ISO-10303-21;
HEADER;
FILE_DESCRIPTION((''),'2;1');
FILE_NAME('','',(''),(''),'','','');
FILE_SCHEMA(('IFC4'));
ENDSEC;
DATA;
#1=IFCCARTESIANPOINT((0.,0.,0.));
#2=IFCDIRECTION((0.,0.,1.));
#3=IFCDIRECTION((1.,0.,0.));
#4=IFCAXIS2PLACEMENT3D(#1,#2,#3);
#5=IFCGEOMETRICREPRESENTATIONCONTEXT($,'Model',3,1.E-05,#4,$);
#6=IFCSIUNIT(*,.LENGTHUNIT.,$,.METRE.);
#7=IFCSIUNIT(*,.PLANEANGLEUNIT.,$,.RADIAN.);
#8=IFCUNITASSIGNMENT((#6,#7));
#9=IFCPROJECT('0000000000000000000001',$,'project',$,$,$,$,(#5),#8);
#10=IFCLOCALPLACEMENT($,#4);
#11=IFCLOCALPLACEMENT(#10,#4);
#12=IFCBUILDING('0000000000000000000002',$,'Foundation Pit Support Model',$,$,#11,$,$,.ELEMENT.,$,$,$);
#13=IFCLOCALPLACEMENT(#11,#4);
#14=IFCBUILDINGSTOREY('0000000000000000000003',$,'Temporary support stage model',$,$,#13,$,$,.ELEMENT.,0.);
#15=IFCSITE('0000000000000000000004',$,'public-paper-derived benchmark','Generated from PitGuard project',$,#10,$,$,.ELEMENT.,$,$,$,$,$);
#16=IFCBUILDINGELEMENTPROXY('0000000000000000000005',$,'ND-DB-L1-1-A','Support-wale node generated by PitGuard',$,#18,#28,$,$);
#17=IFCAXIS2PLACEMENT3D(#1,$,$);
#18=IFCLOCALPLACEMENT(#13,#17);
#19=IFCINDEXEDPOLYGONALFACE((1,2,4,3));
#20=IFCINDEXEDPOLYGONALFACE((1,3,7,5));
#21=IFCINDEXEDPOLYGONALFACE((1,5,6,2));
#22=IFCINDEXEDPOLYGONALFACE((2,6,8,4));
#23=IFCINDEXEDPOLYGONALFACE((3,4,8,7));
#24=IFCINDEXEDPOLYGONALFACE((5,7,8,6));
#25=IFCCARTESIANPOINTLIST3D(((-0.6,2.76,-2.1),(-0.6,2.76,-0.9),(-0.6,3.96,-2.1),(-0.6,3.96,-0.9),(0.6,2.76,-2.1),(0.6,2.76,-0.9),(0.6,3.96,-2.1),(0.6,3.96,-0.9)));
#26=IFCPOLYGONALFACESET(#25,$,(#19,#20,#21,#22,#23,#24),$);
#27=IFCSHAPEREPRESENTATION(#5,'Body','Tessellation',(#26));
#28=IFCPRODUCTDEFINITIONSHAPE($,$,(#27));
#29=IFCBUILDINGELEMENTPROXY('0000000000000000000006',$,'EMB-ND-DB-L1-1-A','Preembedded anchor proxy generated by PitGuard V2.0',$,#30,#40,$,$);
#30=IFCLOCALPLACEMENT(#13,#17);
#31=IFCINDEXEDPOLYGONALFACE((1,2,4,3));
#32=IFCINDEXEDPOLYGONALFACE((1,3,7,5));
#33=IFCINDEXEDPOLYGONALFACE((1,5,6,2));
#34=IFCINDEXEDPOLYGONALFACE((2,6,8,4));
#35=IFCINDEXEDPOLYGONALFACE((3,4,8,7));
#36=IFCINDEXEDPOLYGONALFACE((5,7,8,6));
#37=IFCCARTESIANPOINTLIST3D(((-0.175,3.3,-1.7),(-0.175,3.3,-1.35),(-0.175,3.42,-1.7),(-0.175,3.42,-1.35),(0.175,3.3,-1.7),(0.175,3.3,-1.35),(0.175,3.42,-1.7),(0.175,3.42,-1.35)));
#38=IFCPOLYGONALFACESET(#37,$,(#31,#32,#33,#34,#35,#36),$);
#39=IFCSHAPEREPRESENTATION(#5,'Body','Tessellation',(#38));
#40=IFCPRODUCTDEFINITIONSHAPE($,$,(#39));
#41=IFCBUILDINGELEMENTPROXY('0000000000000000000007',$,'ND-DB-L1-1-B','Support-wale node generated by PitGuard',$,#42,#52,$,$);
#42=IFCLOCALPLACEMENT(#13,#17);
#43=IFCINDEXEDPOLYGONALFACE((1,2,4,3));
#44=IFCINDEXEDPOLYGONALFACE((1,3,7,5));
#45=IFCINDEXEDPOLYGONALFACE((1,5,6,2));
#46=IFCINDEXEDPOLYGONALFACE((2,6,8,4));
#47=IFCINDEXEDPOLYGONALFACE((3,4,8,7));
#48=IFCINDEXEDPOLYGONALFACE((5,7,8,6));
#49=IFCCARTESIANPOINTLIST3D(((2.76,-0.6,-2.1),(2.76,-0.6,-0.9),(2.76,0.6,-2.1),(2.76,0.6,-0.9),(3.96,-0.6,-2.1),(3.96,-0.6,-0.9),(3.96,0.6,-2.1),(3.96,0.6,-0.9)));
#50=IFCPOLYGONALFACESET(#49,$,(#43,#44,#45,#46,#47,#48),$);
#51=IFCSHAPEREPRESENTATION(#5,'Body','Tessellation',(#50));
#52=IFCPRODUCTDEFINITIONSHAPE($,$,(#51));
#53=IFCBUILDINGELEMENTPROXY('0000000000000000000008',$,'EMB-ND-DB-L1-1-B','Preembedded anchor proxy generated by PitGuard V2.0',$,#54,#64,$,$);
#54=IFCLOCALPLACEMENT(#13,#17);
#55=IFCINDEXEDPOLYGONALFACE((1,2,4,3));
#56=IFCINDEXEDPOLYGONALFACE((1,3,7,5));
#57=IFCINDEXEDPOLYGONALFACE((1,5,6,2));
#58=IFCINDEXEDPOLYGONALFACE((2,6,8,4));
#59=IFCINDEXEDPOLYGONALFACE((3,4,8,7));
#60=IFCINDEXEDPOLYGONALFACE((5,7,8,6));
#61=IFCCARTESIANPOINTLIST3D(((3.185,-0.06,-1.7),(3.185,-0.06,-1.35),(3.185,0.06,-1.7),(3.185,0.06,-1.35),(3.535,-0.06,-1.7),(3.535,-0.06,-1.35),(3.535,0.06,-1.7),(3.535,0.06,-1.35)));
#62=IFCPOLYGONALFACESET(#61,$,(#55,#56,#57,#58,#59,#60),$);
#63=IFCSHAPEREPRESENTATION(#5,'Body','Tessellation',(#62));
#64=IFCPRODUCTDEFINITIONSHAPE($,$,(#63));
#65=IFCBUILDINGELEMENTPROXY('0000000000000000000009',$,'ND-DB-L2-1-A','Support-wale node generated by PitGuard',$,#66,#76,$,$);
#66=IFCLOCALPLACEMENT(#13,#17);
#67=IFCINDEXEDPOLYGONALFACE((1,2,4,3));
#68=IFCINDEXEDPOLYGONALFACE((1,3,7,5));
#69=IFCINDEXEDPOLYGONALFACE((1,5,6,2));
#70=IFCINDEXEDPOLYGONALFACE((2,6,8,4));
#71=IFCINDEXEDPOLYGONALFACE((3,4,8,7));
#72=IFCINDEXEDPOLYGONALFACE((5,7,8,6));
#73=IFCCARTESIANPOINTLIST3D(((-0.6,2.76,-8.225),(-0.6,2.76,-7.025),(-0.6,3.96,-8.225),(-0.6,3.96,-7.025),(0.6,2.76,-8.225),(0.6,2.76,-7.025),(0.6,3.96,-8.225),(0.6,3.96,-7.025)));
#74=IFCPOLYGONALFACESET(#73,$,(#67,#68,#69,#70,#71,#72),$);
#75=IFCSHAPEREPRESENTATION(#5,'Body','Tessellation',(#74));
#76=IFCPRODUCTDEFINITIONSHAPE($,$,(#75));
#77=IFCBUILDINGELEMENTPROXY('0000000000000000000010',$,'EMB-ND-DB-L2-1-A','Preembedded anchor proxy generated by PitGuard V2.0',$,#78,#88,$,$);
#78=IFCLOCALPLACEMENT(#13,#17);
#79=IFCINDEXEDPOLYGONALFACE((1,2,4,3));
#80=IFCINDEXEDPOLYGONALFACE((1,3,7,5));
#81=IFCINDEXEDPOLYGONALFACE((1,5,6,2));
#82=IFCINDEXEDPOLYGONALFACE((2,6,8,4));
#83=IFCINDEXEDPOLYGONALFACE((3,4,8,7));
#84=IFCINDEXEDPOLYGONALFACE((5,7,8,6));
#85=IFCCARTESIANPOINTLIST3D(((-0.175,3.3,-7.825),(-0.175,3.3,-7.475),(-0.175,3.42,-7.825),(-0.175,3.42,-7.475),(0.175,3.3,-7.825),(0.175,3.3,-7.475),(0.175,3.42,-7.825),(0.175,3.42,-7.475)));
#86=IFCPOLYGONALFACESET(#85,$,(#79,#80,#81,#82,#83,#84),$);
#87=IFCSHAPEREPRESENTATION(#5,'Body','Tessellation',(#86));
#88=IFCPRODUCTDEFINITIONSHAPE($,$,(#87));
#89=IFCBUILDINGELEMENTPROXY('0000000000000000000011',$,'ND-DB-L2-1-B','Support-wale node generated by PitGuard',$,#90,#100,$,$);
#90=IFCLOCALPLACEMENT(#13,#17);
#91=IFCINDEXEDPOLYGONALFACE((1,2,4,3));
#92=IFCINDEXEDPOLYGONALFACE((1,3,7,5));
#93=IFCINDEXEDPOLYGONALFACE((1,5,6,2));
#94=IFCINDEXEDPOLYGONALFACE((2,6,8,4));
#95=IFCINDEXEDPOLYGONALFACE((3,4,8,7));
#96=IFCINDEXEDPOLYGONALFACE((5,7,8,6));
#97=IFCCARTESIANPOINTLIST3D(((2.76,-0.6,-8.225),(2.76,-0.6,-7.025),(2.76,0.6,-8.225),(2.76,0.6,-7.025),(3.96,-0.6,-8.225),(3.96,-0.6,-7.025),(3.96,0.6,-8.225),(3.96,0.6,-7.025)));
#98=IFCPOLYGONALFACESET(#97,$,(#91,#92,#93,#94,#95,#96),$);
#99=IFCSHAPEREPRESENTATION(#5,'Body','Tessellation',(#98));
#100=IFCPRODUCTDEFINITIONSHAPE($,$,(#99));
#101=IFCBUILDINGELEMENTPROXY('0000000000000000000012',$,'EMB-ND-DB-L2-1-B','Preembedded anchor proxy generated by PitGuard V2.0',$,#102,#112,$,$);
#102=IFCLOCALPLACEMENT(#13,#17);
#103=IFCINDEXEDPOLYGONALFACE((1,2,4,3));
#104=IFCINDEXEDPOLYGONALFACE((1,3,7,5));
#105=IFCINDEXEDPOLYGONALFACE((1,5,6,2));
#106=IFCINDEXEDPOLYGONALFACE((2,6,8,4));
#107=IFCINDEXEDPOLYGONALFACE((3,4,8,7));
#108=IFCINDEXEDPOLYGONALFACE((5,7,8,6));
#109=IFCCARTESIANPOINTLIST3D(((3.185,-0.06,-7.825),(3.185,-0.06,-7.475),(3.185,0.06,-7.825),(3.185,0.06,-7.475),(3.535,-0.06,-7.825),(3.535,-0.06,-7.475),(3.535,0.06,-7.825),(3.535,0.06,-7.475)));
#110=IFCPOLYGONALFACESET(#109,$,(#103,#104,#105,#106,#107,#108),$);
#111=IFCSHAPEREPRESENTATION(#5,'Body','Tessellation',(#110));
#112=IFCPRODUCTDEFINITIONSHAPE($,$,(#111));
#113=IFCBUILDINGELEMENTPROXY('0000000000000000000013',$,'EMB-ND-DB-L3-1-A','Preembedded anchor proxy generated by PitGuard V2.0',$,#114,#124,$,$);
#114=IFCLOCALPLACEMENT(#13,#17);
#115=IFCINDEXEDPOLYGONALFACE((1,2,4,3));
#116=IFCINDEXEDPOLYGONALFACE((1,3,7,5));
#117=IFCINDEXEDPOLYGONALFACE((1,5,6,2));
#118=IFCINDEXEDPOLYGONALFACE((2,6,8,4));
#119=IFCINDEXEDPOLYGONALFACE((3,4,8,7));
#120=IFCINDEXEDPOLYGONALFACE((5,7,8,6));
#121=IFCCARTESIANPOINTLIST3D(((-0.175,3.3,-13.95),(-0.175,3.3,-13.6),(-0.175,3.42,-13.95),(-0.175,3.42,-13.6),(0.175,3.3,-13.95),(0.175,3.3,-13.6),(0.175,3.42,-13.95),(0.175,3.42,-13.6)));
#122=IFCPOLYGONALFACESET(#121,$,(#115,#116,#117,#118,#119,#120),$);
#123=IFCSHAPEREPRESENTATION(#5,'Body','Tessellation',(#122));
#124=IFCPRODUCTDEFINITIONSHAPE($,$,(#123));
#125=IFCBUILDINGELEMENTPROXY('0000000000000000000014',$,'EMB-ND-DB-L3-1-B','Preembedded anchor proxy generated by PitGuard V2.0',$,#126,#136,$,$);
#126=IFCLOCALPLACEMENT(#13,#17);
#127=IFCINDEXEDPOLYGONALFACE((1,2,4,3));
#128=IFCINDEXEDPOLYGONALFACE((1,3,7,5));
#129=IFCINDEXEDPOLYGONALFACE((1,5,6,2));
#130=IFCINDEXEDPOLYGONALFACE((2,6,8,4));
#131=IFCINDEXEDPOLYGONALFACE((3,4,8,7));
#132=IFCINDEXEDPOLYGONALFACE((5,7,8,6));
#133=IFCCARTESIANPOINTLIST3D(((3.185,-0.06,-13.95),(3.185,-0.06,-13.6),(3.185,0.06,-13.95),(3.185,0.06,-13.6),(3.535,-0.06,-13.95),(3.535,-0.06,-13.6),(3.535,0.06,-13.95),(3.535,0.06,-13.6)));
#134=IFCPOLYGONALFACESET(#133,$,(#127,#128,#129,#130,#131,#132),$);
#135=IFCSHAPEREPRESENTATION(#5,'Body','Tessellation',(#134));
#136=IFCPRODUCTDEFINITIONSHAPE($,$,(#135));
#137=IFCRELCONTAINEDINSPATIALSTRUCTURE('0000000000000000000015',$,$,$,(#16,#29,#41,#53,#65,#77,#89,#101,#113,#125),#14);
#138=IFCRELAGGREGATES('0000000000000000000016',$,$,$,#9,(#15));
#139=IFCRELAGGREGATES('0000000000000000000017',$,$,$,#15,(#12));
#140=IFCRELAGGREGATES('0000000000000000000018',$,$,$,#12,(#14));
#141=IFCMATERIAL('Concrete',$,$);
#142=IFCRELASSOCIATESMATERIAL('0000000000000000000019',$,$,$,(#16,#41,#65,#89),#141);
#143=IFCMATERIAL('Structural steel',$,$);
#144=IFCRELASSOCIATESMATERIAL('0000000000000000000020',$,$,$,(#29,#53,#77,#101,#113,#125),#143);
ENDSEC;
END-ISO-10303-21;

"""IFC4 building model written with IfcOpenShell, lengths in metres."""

from ifc_helpers import new_model, si_unit, frame, origin_with_axes, origin_2d, place, context, project, spatial, rectangle, extrude, material, element, save


model = new_model("IFC4")

# Units and contexts
model_context = context("Model", 3, precision=1e-05, world=origin_with_axes())
ifc_project = project(units=[si_unit("LENGTHUNIT", "METRE"), si_unit("PLANEANGLEUNIT", "RADIAN")], contexts=[model_context])

# Site, building, storey
site_placement = place(None, origin_with_axes())
site = spatial("IfcSite", under=ifc_project, at=site_placement, Name="public-paper-derived benchmark", Description="Generated from PitGuard project", CompositionType="ELEMENT")
building_placement = place(site_placement, origin_with_axes())
building = spatial("IfcBuilding", under=site, at=building_placement, Name="Foundation Pit Support Model", CompositionType="ELEMENT")
storey_placement = place(building_placement, origin_with_axes())
storey = spatial("IfcBuildingStorey", under=building, at=storey_placement, Name="Temporary support stage model", CompositionType="ELEMENT", Elevation=0.0)

# Shared definitions
ifc_material_1 = material(Name="Concrete")

# Shared definitions
ifc_material_2 = material(Name="Structural steel")

# Building element proxies
proxy_1_placement = place(storey_placement, frame((0.0, 3.36, -2.1), z_axis=(0.0, 0.0, 1.0), x_axis=(1.0, 0.0, 0.0)))
element("IfcBuildingElementProxy", 1, at=proxy_1_placement, inside=storey, material=ifc_material_1, Name="ND-DB-L1-1-A", Description="Support-wale node generated by PitGuard", context=model_context, shape_type="SweptSolid", body=[
    extrude(rectangle(XDim=1.2, YDim=1.2, at=origin_2d()), origin_with_axes(), (0.0, 0.0, 1.0), 1.2),
])
proxy_2_placement = place(storey_placement, frame((0.0, 3.36, -1.7), z_axis=(0.0, 0.0, 1.0), x_axis=(1.0, 0.0, 0.0)))
element("IfcBuildingElementProxy", 2, at=proxy_2_placement, inside=storey, material=ifc_material_2, Name="EMB-ND-DB-L1-1-A", Description="Preembedded anchor proxy generated by PitGuard V2.0", context=model_context, shape_type="SweptSolid", body=[
    extrude(rectangle(XDim=0.35, YDim=0.12, at=origin_2d()), origin_with_axes(), (0.0, 0.0, 1.0), 0.35),
])
proxy_3_placement = place(storey_placement, frame((3.36, 0.0, -2.1), z_axis=(0.0, 0.0, 1.0), x_axis=(1.0, 0.0, 0.0)))
element("IfcBuildingElementProxy", 3, at=proxy_3_placement, inside=storey, material=ifc_material_1, Name="ND-DB-L1-1-B", Description="Support-wale node generated by PitGuard", context=model_context, shape_type="SweptSolid", body=[
    extrude(rectangle(XDim=1.2, YDim=1.2, at=origin_2d()), origin_with_axes(), (0.0, 0.0, 1.0), 1.2),
])
proxy_4_placement = place(storey_placement, frame((3.36, 0.0, -1.7), z_axis=(0.0, 0.0, 1.0), x_axis=(1.0, 0.0, 0.0)))
element("IfcBuildingElementProxy", 4, at=proxy_4_placement, inside=storey, material=ifc_material_2, Name="EMB-ND-DB-L1-1-B", Description="Preembedded anchor proxy generated by PitGuard V2.0", context=model_context, shape_type="SweptSolid", body=[
    extrude(rectangle(XDim=0.35, YDim=0.12, at=origin_2d()), origin_with_axes(), (0.0, 0.0, 1.0), 0.35),
])
proxy_5_placement = place(storey_placement, frame((0.0, 3.36, -8.225), z_axis=(0.0, 0.0, 1.0), x_axis=(1.0, 0.0, 0.0)))
element("IfcBuildingElementProxy", 5, at=proxy_5_placement, inside=storey, material=ifc_material_1, Name="ND-DB-L2-1-A", Description="Support-wale node generated by PitGuard", context=model_context, shape_type="SweptSolid", body=[
    extrude(rectangle(XDim=1.2, YDim=1.2, at=origin_2d()), origin_with_axes(), (0.0, 0.0, 1.0), 1.2),
])
proxy_6_placement = place(storey_placement, frame((0.0, 3.36, -7.825), z_axis=(0.0, 0.0, 1.0), x_axis=(1.0, 0.0, 0.0)))
element("IfcBuildingElementProxy", 6, at=proxy_6_placement, inside=storey, material=ifc_material_2, Name="EMB-ND-DB-L2-1-A", Description="Preembedded anchor proxy generated by PitGuard V2.0", context=model_context, shape_type="SweptSolid", body=[
    extrude(rectangle(XDim=0.35, YDim=0.12, at=origin_2d()), origin_with_axes(), (0.0, 0.0, 1.0), 0.35),
])
proxy_7_placement = place(storey_placement, frame((3.36, 0.0, -8.225), z_axis=(0.0, 0.0, 1.0), x_axis=(1.0, 0.0, 0.0)))
element("IfcBuildingElementProxy", 7, at=proxy_7_placement, inside=storey, material=ifc_material_1, Name="ND-DB-L2-1-B", Description="Support-wale node generated by PitGuard", context=model_context, shape_type="SweptSolid", body=[
    extrude(rectangle(XDim=1.2, YDim=1.2, at=origin_2d()), origin_with_axes(), (0.0, 0.0, 1.0), 1.2),
])
for number, where, z_axis, x_axis, name in (
    (8, (3.36, 0.0, -7.825), (0.0, 0.0, 1.0), (1.0, 0.0, 0.0), "EMB-ND-DB-L2-1-B"),
    (9, (0.0, 3.36, -13.95), (0.0, 0.0, 1.0), (1.0, 0.0, 0.0), "EMB-ND-DB-L3-1-A"),
    (10, (3.36, 0.0, -13.95), (0.0, 0.0, 1.0), (1.0, 0.0, 0.0), "EMB-ND-DB-L3-1-B"),
):
    element("IfcBuildingElementProxy", number, at=place(storey_placement, frame(where, z_axis=z_axis, x_axis=x_axis)), inside=storey, material=ifc_material_2, Name=name, Description="Preembedded anchor proxy generated by PitGuard V2.0", context=model_context, shape_type="SweptSolid", body=[
        extrude(rectangle(XDim=0.35, YDim=0.12, at=origin_2d()), origin_with_axes(), (0.0, 0.0, 1.0), 0.35),
    ])

save(model, "model.ifc")
